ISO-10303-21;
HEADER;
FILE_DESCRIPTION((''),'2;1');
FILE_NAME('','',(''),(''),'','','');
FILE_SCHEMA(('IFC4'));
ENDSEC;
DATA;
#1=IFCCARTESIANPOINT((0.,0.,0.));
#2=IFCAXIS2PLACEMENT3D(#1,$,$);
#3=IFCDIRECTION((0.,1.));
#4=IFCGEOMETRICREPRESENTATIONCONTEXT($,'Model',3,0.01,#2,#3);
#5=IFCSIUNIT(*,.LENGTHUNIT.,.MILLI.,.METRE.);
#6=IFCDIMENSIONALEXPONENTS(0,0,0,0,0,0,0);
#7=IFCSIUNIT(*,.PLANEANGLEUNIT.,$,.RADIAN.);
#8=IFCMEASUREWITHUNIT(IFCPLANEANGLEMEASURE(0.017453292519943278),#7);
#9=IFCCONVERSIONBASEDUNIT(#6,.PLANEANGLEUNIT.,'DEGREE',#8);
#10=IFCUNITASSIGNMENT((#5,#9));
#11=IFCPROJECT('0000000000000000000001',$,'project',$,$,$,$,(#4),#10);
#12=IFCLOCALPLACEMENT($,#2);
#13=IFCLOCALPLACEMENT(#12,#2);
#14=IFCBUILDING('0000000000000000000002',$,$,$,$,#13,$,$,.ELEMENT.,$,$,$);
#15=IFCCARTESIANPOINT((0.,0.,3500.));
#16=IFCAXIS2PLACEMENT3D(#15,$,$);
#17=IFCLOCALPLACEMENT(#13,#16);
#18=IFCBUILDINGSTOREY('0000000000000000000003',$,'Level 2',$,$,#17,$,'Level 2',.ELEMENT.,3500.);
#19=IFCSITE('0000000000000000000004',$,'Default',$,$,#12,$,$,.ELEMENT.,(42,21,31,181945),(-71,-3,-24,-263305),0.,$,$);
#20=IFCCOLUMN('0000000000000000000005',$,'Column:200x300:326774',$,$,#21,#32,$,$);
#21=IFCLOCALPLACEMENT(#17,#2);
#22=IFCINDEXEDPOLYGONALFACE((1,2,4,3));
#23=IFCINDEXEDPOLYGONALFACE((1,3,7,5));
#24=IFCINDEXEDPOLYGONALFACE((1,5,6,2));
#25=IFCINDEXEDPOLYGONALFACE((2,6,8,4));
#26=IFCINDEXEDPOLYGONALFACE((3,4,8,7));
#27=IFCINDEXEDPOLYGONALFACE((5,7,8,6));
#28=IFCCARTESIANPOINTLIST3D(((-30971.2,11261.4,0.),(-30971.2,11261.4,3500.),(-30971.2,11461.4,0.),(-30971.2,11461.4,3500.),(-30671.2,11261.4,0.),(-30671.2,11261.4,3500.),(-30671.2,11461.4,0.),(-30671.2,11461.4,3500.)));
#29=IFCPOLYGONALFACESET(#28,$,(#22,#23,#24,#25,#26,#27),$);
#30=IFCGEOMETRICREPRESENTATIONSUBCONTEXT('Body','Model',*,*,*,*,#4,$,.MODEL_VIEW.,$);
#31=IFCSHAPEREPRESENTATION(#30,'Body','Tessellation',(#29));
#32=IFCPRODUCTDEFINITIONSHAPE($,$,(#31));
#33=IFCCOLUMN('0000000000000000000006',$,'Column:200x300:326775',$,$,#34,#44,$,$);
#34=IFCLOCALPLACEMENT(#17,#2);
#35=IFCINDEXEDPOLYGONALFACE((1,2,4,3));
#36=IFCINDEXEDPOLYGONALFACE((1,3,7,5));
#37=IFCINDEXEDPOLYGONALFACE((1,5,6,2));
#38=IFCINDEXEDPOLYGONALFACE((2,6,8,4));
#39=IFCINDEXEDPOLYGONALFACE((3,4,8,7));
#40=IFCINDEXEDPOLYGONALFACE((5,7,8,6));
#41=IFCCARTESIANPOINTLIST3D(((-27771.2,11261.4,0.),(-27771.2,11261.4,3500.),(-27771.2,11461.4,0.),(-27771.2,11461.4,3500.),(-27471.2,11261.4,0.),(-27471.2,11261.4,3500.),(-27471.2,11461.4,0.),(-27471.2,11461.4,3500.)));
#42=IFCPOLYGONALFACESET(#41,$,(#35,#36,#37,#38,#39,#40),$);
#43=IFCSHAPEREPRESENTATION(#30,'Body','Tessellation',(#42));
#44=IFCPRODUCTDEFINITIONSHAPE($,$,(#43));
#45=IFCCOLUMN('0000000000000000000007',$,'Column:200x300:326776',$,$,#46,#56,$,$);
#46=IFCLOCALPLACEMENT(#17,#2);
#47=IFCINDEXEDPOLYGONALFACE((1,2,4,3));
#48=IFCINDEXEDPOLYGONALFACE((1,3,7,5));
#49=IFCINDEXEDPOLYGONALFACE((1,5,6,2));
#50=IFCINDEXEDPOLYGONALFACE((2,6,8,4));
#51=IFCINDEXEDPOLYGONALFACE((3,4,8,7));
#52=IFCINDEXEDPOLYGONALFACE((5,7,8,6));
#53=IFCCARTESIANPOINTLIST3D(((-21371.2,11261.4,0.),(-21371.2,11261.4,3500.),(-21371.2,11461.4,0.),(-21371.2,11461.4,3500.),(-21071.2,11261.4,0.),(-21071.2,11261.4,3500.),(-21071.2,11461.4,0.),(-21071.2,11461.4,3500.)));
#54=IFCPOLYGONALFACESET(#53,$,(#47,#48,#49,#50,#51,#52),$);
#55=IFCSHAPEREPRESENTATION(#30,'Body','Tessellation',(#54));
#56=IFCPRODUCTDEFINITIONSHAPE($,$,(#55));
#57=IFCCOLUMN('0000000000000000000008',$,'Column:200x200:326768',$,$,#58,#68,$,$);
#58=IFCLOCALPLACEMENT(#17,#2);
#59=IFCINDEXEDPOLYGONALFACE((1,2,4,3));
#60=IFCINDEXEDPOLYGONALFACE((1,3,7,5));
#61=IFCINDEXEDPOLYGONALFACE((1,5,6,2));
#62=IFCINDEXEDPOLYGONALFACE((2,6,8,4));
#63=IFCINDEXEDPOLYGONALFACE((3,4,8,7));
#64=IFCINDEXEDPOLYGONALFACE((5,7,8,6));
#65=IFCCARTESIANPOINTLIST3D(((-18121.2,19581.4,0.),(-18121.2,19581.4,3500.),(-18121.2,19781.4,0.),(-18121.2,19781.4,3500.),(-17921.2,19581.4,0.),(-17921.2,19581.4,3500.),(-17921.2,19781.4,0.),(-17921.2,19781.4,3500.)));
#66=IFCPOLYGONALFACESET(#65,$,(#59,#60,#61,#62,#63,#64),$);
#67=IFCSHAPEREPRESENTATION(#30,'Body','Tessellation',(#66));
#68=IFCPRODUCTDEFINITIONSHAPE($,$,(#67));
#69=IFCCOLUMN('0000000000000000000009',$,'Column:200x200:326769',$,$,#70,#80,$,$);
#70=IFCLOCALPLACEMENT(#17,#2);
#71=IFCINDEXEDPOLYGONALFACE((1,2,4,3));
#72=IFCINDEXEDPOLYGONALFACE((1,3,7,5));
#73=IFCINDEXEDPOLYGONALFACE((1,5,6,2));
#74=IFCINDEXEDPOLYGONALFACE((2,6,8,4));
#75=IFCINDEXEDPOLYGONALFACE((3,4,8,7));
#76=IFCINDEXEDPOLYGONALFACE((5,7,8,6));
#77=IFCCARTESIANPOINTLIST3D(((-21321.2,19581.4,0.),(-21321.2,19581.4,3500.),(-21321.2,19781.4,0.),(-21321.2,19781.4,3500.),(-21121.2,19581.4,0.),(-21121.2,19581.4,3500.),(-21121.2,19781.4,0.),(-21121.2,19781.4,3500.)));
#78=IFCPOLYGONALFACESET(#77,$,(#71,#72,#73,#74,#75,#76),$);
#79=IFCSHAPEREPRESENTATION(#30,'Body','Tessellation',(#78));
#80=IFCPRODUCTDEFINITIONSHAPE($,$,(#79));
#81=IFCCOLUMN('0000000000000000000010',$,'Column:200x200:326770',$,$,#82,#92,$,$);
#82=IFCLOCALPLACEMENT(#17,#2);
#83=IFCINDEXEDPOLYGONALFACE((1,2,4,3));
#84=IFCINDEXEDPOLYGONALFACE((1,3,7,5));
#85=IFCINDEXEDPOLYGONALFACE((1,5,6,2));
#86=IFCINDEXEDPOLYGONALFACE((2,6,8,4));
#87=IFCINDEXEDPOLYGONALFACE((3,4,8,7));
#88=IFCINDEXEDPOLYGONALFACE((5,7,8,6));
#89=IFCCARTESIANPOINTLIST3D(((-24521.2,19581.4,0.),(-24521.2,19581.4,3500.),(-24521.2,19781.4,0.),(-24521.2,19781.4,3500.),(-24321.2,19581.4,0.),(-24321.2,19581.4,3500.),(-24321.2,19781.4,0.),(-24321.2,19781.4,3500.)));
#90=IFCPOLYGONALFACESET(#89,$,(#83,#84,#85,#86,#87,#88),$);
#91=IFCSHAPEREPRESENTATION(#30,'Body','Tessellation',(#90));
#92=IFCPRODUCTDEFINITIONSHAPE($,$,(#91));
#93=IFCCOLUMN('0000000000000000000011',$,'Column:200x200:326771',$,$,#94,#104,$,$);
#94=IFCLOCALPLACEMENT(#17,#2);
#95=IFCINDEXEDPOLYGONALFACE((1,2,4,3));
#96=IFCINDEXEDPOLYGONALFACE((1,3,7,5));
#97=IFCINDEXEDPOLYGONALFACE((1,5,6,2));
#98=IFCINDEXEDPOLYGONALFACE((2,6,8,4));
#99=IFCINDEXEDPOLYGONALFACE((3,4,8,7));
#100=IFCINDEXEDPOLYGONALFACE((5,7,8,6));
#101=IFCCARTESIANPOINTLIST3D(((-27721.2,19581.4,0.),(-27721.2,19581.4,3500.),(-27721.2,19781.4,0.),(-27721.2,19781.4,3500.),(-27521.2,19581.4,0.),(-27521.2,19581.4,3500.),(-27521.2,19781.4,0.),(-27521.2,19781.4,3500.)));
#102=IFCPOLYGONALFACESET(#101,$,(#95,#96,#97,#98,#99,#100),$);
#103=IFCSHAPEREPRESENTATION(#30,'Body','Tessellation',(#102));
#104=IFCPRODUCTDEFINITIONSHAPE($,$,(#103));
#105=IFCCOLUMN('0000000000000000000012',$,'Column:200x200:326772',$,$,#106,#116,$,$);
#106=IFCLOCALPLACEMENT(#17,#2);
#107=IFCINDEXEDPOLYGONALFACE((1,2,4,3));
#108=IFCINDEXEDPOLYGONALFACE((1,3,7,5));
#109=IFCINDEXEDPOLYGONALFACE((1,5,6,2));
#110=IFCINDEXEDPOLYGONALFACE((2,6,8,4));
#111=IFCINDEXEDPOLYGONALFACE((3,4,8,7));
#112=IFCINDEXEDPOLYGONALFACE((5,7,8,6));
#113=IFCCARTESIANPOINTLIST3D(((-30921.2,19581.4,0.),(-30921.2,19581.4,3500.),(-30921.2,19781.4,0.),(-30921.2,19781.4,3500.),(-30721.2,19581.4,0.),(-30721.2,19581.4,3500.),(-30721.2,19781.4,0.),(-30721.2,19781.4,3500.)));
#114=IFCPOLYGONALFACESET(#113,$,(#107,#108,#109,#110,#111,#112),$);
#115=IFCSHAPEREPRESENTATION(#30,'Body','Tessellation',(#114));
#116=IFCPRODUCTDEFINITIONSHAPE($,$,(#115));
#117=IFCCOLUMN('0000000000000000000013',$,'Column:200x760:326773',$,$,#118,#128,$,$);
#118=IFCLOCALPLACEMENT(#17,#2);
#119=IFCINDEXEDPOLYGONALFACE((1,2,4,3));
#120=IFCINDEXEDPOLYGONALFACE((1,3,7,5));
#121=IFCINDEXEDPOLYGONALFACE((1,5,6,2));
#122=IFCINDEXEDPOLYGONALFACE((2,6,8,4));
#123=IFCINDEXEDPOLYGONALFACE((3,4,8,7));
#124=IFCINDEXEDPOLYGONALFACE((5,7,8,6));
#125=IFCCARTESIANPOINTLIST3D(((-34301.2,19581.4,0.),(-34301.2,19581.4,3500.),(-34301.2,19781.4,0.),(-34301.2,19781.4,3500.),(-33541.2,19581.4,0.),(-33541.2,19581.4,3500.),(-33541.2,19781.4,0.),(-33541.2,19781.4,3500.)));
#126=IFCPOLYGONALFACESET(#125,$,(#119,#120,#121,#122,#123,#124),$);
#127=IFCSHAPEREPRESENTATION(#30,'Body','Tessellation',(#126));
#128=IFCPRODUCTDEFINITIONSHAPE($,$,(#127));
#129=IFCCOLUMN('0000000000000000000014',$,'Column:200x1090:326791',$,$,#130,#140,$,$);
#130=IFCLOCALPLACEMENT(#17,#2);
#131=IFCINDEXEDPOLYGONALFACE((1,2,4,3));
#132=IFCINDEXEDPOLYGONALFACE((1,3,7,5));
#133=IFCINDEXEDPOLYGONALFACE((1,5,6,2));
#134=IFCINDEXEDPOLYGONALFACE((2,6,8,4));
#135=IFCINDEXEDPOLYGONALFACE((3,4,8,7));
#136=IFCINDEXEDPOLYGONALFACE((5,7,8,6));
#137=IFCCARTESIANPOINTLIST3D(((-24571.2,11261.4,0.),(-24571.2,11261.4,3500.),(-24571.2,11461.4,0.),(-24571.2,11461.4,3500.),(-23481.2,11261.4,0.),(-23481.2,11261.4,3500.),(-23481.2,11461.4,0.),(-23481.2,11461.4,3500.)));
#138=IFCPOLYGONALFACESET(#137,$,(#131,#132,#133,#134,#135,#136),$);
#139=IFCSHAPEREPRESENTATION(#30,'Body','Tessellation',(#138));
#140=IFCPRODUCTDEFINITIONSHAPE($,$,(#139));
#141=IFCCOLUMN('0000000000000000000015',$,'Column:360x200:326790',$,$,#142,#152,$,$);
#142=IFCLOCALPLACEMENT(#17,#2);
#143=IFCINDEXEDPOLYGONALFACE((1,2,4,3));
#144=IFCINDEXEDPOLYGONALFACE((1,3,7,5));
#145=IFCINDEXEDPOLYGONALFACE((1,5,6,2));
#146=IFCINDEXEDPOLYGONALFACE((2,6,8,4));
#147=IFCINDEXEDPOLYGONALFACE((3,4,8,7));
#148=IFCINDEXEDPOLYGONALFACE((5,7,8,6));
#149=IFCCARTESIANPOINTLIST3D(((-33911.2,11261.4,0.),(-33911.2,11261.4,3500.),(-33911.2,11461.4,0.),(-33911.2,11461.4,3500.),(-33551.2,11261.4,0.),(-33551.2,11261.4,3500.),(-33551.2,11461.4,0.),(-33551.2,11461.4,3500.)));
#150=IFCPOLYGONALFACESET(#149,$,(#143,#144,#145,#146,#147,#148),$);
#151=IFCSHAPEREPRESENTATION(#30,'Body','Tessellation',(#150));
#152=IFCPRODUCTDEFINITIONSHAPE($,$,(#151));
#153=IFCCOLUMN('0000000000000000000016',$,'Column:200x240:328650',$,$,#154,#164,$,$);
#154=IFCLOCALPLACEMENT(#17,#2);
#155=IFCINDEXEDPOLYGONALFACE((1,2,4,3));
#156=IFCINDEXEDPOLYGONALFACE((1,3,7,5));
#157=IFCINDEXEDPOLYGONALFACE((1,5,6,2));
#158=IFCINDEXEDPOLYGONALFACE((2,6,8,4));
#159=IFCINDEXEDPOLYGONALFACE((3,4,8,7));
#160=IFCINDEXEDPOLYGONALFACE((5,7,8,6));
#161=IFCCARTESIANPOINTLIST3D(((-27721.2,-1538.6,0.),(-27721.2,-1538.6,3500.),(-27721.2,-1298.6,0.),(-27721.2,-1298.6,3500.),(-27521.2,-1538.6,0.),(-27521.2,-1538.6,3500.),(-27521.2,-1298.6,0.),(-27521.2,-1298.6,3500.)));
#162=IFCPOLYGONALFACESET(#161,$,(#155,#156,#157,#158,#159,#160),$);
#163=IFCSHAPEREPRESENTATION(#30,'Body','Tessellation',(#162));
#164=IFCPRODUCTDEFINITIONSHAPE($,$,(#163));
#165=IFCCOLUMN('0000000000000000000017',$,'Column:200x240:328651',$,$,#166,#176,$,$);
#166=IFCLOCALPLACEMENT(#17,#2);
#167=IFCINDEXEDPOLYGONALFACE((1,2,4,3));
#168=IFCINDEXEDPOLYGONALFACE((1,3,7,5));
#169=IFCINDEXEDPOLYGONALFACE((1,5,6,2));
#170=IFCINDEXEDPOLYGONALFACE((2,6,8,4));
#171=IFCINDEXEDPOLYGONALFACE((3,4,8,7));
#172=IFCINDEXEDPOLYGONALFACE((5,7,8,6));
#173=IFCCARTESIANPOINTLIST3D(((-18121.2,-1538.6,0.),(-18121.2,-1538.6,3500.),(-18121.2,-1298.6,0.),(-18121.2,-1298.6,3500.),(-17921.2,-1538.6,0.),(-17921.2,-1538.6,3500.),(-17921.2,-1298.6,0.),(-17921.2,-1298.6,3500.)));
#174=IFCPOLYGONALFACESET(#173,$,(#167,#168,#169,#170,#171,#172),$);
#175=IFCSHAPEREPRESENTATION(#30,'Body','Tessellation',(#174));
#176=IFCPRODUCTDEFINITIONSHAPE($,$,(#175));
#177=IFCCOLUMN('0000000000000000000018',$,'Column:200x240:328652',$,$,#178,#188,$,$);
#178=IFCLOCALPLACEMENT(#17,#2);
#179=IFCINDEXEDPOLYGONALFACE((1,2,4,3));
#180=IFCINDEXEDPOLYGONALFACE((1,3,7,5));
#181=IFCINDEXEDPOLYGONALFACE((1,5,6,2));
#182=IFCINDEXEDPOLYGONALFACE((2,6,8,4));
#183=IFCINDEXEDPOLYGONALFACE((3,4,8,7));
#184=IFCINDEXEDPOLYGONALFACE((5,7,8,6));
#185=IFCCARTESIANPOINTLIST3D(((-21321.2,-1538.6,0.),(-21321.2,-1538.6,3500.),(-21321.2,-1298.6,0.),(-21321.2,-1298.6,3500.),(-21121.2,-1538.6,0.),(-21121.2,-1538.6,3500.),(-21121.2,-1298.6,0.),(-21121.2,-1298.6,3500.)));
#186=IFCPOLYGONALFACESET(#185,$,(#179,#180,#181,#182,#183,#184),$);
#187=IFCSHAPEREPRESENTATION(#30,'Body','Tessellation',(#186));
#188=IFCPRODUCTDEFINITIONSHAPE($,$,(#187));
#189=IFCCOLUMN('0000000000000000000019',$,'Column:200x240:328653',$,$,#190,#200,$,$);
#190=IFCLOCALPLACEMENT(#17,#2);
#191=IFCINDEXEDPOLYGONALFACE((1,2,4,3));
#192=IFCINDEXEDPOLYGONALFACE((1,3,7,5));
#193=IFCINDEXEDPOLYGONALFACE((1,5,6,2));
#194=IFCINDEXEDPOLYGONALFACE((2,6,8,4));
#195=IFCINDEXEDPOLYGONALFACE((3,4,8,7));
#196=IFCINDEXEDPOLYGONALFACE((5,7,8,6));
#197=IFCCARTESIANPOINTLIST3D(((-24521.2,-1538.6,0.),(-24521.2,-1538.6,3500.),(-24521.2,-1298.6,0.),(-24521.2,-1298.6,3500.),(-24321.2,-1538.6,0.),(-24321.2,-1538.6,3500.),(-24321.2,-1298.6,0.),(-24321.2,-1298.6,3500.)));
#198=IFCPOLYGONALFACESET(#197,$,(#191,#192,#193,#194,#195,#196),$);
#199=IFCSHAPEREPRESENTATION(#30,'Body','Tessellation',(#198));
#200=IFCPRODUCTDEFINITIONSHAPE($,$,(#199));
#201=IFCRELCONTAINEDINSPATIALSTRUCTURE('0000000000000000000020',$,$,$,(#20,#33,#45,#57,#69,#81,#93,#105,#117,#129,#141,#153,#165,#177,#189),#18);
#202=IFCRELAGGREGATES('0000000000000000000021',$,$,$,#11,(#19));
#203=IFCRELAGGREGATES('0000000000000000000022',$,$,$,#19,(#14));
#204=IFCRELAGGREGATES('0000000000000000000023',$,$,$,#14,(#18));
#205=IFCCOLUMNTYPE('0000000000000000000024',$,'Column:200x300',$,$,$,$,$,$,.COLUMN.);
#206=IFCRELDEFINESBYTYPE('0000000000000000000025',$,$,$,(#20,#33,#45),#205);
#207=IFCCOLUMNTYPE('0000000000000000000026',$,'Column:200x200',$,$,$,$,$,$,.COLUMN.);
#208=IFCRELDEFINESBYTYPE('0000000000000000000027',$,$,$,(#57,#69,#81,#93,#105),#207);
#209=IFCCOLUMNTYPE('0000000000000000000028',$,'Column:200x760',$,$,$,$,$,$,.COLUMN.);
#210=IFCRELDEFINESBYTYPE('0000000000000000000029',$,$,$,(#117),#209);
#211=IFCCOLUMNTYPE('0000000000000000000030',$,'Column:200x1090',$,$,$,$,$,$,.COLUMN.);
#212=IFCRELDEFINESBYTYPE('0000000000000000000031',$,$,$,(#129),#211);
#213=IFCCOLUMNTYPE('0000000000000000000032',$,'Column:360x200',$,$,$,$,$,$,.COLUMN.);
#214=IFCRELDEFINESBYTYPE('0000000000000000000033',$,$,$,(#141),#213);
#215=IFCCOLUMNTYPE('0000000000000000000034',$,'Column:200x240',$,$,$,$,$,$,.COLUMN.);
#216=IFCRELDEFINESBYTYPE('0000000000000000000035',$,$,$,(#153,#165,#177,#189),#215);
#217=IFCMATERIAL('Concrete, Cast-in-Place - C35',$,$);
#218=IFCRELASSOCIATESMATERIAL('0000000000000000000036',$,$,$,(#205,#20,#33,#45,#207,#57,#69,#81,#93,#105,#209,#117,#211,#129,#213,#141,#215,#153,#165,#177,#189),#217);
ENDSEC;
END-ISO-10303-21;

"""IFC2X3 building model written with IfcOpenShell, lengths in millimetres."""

from ifc_helpers import new_model, entity, si_unit, converted_unit, direction, frame, frame_2d, origin, origin_2d_with_axis, place, context, subcontext, project, spatial, rectangle, extrude, source, transform, mapped, material, type_object, type_shapes, element, save


model = new_model("IFC2X3")

# Units and contexts
model_context = context("Model", 3, precision=0.01, world=origin(), true_north=direction((0.0, 1.0)))
body_context = subcontext(model_context, "Body", "Model", "MODEL_VIEW")
ifc_project = project(units=[si_unit("LENGTHUNIT", "METRE", prefix="MILLI"), converted_unit("PLANEANGLEUNIT", "DEGREE", entity("IfcPlaneAngleMeasure", 0.017453292519943278), si_unit("PLANEANGLEUNIT", "RADIAN"), dimensions=[0, 0, 0, 0, 0, 0, 0])], contexts=[model_context])

# Site, building, storey
site_placement = place(None, origin())
site = spatial("IfcSite", under=ifc_project, at=site_placement, Name="Default", CompositionType="ELEMENT", RefLatitude=(42, 21, 31, 181945), RefLongitude=(-71, -3, -24, -263305), RefElevation=0.0)
building_placement = place(site_placement, origin())
building = spatial("IfcBuilding", under=site, at=building_placement, CompositionType="ELEMENT")
storey_placement = place(building_placement, frame((0.0, 0.0, 3500.0)))
storey = spatial("IfcBuildingStorey", under=building, at=storey_placement, Name="Level 2", LongName="Level 2", CompositionType="ELEMENT", Elevation=3500.0)

# Columns
ifc_material = material(Name="Concrete, Cast-in-Place - C35")
column_type_1 = type_object("IfcColumnType", Name="Column:200x300", PredefinedType="COLUMN", material=ifc_material)
shared_shape_1 = source(origin(), body_context, "Body", "SweptSolid", [
    extrude(rectangle(XDim=300.0, YDim=200.0, at=origin_2d_with_axis()), frame((-50.0, 0.0, 3500.0), z_axis=(0.0, 0.0, 1.0), x_axis=(-1.0, 0.0, 0.0)), (0.0, 0.0, 1.0), 3500.0),
])
type_shapes(column_type_1, [shared_shape_1])
for number, where, name in (
    (1, (-30771.2, 11361.4, -3500.0), "Column:200x300:326774"),
    (2, (-27571.2, 11361.4, -3500.0), "Column:200x300:326775"),
    (3, (-21171.2, 11361.4, -3500.0), "Column:200x300:326776"),
):
    element("IfcColumn", number, at=place(storey_placement, frame(where)), inside=storey, type_object=column_type_1, material=ifc_material, Name=name, context=body_context, shape_type="MappedRepresentation", body=[
        mapped(shared_shape_1, transform((0.0, 0.0, 0.0), scale=1.0)),
    ])
column_type_2 = type_object("IfcColumnType", Name="Column:200x200", PredefinedType="COLUMN", material=ifc_material)
shared_shape_2 = source(origin(), body_context, "Body", "SweptSolid", [
    extrude(rectangle(XDim=200.0, YDim=200.0, at=frame_2d((0.0, 0.0), x_axis=(1.0, 0.0))), frame((0.0, 0.0, 3500.0), z_axis=(0.0, 0.0, 1.0), x_axis=(-1.0, 0.0, 0.0)), (0.0, 0.0, 1.0), 3500.0),
])
type_shapes(column_type_2, [shared_shape_2])
for number, where, name in (
    (4, (-18021.2, 19681.4, -3500.0), "Column:200x200:326768"),
    (5, (-21221.2, 19681.4, -3500.0), "Column:200x200:326769"),
    (6, (-24421.2, 19681.4, -3500.0), "Column:200x200:326770"),
    (7, (-27621.2, 19681.4, -3500.0), "Column:200x200:326771"),
    (8, (-30821.2, 19681.4, -3500.0), "Column:200x200:326772"),
):
    element("IfcColumn", number, at=place(storey_placement, frame(where)), inside=storey, type_object=column_type_2, material=ifc_material, Name=name, context=body_context, shape_type="MappedRepresentation", body=[
        mapped(shared_shape_2, transform((0.0, 0.0, 0.0), scale=1.0)),
    ])
column_type_3 = type_object("IfcColumnType", Name="Column:200x760", PredefinedType="COLUMN", material=ifc_material)
shared_shape_3 = source(origin(), body_context, "Body", "SweptSolid", [
    extrude(rectangle(XDim=760.0, YDim=200.0, at=origin_2d_with_axis()), frame((-280.0, 0.0, 3500.0), z_axis=(0.0, 0.0, 1.0), x_axis=(-1.0, 0.0, 0.0)), (0.0, 0.0, 1.0), 3500.0),
])
type_shapes(column_type_3, [shared_shape_3])
column_1_placement = place(storey_placement, frame((-33641.2, 19681.4, -3500.0)))
element("IfcColumn", 9, at=column_1_placement, inside=storey, type_object=column_type_3, material=ifc_material, Name="Column:200x760:326773", context=body_context, shape_type="MappedRepresentation", body=[
    mapped(shared_shape_3, transform((0.0, 0.0, 0.0), scale=1.0)),
])
column_type_4 = type_object("IfcColumnType", Name="Column:200x1090", PredefinedType="COLUMN", material=ifc_material)
shared_shape_4 = source(origin(), body_context, "Body", "SweptSolid", [
    extrude(rectangle(XDim=1090.0, YDim=200.0, at=origin_2d_with_axis()), frame((-445.0, 0.0, 3500.0), z_axis=(0.0, 0.0, 1.0), x_axis=(-1.0, 0.0, 0.0)), (0.0, 0.0, 1.0), 3500.0),
])
type_shapes(column_type_4, [shared_shape_4])
column_2_placement = place(storey_placement, frame((-23581.2, 11361.4, -3500.0)))
element("IfcColumn", 10, at=column_2_placement, inside=storey, type_object=column_type_4, material=ifc_material, Name="Column:200x1090:326791", context=body_context, shape_type="MappedRepresentation", body=[
    mapped(shared_shape_4, transform((0.0, 0.0, 0.0), scale=1.0)),
])
column_type_5 = type_object("IfcColumnType", Name="Column:360x200", PredefinedType="COLUMN", material=ifc_material)
shared_shape_5 = source(origin(), body_context, "Body", "SweptSolid", [
    extrude(rectangle(XDim=360.0, YDim=200.0, at=origin_2d_with_axis()), frame((-80.0, 0.0, 3500.0), z_axis=(0.0, 0.0, 1.0), x_axis=(-1.0, 0.0, 0.0)), (0.0, 0.0, 1.0), 3500.0),
])
type_shapes(column_type_5, [shared_shape_5])
column_3_placement = place(storey_placement, frame((-33651.2, 11361.4, -3500.0)))
element("IfcColumn", 11, at=column_3_placement, inside=storey, type_object=column_type_5, material=ifc_material, Name="Column:360x200:326790", context=body_context, shape_type="MappedRepresentation", body=[
    mapped(shared_shape_5, transform((0.0, 0.0, 0.0), scale=1.0)),
])
column_type_6 = type_object("IfcColumnType", Name="Column:200x240", PredefinedType="COLUMN", material=ifc_material)
shared_shape_6 = source(origin(), body_context, "Body", "SweptSolid", [
    extrude(rectangle(XDim=200.0, YDim=240.0, at=frame_2d((0.0, 0.0), x_axis=(1.0, 0.0))), frame((0.0, 20.0, 3500.0), z_axis=(0.0, 0.0, 1.0), x_axis=(-1.0, 0.0, 0.0)), (0.0, 0.0, 1.0), 3500.0),
])
type_shapes(column_type_6, [shared_shape_6])
for number, where, name in (
    (12, (-27621.2, -1438.6, -3500.0), "Column:200x240:328650"),
    (13, (-18021.2, -1438.6, -3500.0), "Column:200x240:328651"),
    (14, (-21221.2, -1438.6, -3500.0), "Column:200x240:328652"),
    (15, (-24421.2, -1438.6, -3500.0), "Column:200x240:328653"),
):
    element("IfcColumn", number, at=place(storey_placement, frame(where)), inside=storey, type_object=column_type_6, material=ifc_material, Name=name, context=body_context, shape_type="MappedRepresentation", body=[
        mapped(shared_shape_6, transform((0.0, 0.0, 0.0), scale=1.0)),
    ])

save(model, "model.ifc")
